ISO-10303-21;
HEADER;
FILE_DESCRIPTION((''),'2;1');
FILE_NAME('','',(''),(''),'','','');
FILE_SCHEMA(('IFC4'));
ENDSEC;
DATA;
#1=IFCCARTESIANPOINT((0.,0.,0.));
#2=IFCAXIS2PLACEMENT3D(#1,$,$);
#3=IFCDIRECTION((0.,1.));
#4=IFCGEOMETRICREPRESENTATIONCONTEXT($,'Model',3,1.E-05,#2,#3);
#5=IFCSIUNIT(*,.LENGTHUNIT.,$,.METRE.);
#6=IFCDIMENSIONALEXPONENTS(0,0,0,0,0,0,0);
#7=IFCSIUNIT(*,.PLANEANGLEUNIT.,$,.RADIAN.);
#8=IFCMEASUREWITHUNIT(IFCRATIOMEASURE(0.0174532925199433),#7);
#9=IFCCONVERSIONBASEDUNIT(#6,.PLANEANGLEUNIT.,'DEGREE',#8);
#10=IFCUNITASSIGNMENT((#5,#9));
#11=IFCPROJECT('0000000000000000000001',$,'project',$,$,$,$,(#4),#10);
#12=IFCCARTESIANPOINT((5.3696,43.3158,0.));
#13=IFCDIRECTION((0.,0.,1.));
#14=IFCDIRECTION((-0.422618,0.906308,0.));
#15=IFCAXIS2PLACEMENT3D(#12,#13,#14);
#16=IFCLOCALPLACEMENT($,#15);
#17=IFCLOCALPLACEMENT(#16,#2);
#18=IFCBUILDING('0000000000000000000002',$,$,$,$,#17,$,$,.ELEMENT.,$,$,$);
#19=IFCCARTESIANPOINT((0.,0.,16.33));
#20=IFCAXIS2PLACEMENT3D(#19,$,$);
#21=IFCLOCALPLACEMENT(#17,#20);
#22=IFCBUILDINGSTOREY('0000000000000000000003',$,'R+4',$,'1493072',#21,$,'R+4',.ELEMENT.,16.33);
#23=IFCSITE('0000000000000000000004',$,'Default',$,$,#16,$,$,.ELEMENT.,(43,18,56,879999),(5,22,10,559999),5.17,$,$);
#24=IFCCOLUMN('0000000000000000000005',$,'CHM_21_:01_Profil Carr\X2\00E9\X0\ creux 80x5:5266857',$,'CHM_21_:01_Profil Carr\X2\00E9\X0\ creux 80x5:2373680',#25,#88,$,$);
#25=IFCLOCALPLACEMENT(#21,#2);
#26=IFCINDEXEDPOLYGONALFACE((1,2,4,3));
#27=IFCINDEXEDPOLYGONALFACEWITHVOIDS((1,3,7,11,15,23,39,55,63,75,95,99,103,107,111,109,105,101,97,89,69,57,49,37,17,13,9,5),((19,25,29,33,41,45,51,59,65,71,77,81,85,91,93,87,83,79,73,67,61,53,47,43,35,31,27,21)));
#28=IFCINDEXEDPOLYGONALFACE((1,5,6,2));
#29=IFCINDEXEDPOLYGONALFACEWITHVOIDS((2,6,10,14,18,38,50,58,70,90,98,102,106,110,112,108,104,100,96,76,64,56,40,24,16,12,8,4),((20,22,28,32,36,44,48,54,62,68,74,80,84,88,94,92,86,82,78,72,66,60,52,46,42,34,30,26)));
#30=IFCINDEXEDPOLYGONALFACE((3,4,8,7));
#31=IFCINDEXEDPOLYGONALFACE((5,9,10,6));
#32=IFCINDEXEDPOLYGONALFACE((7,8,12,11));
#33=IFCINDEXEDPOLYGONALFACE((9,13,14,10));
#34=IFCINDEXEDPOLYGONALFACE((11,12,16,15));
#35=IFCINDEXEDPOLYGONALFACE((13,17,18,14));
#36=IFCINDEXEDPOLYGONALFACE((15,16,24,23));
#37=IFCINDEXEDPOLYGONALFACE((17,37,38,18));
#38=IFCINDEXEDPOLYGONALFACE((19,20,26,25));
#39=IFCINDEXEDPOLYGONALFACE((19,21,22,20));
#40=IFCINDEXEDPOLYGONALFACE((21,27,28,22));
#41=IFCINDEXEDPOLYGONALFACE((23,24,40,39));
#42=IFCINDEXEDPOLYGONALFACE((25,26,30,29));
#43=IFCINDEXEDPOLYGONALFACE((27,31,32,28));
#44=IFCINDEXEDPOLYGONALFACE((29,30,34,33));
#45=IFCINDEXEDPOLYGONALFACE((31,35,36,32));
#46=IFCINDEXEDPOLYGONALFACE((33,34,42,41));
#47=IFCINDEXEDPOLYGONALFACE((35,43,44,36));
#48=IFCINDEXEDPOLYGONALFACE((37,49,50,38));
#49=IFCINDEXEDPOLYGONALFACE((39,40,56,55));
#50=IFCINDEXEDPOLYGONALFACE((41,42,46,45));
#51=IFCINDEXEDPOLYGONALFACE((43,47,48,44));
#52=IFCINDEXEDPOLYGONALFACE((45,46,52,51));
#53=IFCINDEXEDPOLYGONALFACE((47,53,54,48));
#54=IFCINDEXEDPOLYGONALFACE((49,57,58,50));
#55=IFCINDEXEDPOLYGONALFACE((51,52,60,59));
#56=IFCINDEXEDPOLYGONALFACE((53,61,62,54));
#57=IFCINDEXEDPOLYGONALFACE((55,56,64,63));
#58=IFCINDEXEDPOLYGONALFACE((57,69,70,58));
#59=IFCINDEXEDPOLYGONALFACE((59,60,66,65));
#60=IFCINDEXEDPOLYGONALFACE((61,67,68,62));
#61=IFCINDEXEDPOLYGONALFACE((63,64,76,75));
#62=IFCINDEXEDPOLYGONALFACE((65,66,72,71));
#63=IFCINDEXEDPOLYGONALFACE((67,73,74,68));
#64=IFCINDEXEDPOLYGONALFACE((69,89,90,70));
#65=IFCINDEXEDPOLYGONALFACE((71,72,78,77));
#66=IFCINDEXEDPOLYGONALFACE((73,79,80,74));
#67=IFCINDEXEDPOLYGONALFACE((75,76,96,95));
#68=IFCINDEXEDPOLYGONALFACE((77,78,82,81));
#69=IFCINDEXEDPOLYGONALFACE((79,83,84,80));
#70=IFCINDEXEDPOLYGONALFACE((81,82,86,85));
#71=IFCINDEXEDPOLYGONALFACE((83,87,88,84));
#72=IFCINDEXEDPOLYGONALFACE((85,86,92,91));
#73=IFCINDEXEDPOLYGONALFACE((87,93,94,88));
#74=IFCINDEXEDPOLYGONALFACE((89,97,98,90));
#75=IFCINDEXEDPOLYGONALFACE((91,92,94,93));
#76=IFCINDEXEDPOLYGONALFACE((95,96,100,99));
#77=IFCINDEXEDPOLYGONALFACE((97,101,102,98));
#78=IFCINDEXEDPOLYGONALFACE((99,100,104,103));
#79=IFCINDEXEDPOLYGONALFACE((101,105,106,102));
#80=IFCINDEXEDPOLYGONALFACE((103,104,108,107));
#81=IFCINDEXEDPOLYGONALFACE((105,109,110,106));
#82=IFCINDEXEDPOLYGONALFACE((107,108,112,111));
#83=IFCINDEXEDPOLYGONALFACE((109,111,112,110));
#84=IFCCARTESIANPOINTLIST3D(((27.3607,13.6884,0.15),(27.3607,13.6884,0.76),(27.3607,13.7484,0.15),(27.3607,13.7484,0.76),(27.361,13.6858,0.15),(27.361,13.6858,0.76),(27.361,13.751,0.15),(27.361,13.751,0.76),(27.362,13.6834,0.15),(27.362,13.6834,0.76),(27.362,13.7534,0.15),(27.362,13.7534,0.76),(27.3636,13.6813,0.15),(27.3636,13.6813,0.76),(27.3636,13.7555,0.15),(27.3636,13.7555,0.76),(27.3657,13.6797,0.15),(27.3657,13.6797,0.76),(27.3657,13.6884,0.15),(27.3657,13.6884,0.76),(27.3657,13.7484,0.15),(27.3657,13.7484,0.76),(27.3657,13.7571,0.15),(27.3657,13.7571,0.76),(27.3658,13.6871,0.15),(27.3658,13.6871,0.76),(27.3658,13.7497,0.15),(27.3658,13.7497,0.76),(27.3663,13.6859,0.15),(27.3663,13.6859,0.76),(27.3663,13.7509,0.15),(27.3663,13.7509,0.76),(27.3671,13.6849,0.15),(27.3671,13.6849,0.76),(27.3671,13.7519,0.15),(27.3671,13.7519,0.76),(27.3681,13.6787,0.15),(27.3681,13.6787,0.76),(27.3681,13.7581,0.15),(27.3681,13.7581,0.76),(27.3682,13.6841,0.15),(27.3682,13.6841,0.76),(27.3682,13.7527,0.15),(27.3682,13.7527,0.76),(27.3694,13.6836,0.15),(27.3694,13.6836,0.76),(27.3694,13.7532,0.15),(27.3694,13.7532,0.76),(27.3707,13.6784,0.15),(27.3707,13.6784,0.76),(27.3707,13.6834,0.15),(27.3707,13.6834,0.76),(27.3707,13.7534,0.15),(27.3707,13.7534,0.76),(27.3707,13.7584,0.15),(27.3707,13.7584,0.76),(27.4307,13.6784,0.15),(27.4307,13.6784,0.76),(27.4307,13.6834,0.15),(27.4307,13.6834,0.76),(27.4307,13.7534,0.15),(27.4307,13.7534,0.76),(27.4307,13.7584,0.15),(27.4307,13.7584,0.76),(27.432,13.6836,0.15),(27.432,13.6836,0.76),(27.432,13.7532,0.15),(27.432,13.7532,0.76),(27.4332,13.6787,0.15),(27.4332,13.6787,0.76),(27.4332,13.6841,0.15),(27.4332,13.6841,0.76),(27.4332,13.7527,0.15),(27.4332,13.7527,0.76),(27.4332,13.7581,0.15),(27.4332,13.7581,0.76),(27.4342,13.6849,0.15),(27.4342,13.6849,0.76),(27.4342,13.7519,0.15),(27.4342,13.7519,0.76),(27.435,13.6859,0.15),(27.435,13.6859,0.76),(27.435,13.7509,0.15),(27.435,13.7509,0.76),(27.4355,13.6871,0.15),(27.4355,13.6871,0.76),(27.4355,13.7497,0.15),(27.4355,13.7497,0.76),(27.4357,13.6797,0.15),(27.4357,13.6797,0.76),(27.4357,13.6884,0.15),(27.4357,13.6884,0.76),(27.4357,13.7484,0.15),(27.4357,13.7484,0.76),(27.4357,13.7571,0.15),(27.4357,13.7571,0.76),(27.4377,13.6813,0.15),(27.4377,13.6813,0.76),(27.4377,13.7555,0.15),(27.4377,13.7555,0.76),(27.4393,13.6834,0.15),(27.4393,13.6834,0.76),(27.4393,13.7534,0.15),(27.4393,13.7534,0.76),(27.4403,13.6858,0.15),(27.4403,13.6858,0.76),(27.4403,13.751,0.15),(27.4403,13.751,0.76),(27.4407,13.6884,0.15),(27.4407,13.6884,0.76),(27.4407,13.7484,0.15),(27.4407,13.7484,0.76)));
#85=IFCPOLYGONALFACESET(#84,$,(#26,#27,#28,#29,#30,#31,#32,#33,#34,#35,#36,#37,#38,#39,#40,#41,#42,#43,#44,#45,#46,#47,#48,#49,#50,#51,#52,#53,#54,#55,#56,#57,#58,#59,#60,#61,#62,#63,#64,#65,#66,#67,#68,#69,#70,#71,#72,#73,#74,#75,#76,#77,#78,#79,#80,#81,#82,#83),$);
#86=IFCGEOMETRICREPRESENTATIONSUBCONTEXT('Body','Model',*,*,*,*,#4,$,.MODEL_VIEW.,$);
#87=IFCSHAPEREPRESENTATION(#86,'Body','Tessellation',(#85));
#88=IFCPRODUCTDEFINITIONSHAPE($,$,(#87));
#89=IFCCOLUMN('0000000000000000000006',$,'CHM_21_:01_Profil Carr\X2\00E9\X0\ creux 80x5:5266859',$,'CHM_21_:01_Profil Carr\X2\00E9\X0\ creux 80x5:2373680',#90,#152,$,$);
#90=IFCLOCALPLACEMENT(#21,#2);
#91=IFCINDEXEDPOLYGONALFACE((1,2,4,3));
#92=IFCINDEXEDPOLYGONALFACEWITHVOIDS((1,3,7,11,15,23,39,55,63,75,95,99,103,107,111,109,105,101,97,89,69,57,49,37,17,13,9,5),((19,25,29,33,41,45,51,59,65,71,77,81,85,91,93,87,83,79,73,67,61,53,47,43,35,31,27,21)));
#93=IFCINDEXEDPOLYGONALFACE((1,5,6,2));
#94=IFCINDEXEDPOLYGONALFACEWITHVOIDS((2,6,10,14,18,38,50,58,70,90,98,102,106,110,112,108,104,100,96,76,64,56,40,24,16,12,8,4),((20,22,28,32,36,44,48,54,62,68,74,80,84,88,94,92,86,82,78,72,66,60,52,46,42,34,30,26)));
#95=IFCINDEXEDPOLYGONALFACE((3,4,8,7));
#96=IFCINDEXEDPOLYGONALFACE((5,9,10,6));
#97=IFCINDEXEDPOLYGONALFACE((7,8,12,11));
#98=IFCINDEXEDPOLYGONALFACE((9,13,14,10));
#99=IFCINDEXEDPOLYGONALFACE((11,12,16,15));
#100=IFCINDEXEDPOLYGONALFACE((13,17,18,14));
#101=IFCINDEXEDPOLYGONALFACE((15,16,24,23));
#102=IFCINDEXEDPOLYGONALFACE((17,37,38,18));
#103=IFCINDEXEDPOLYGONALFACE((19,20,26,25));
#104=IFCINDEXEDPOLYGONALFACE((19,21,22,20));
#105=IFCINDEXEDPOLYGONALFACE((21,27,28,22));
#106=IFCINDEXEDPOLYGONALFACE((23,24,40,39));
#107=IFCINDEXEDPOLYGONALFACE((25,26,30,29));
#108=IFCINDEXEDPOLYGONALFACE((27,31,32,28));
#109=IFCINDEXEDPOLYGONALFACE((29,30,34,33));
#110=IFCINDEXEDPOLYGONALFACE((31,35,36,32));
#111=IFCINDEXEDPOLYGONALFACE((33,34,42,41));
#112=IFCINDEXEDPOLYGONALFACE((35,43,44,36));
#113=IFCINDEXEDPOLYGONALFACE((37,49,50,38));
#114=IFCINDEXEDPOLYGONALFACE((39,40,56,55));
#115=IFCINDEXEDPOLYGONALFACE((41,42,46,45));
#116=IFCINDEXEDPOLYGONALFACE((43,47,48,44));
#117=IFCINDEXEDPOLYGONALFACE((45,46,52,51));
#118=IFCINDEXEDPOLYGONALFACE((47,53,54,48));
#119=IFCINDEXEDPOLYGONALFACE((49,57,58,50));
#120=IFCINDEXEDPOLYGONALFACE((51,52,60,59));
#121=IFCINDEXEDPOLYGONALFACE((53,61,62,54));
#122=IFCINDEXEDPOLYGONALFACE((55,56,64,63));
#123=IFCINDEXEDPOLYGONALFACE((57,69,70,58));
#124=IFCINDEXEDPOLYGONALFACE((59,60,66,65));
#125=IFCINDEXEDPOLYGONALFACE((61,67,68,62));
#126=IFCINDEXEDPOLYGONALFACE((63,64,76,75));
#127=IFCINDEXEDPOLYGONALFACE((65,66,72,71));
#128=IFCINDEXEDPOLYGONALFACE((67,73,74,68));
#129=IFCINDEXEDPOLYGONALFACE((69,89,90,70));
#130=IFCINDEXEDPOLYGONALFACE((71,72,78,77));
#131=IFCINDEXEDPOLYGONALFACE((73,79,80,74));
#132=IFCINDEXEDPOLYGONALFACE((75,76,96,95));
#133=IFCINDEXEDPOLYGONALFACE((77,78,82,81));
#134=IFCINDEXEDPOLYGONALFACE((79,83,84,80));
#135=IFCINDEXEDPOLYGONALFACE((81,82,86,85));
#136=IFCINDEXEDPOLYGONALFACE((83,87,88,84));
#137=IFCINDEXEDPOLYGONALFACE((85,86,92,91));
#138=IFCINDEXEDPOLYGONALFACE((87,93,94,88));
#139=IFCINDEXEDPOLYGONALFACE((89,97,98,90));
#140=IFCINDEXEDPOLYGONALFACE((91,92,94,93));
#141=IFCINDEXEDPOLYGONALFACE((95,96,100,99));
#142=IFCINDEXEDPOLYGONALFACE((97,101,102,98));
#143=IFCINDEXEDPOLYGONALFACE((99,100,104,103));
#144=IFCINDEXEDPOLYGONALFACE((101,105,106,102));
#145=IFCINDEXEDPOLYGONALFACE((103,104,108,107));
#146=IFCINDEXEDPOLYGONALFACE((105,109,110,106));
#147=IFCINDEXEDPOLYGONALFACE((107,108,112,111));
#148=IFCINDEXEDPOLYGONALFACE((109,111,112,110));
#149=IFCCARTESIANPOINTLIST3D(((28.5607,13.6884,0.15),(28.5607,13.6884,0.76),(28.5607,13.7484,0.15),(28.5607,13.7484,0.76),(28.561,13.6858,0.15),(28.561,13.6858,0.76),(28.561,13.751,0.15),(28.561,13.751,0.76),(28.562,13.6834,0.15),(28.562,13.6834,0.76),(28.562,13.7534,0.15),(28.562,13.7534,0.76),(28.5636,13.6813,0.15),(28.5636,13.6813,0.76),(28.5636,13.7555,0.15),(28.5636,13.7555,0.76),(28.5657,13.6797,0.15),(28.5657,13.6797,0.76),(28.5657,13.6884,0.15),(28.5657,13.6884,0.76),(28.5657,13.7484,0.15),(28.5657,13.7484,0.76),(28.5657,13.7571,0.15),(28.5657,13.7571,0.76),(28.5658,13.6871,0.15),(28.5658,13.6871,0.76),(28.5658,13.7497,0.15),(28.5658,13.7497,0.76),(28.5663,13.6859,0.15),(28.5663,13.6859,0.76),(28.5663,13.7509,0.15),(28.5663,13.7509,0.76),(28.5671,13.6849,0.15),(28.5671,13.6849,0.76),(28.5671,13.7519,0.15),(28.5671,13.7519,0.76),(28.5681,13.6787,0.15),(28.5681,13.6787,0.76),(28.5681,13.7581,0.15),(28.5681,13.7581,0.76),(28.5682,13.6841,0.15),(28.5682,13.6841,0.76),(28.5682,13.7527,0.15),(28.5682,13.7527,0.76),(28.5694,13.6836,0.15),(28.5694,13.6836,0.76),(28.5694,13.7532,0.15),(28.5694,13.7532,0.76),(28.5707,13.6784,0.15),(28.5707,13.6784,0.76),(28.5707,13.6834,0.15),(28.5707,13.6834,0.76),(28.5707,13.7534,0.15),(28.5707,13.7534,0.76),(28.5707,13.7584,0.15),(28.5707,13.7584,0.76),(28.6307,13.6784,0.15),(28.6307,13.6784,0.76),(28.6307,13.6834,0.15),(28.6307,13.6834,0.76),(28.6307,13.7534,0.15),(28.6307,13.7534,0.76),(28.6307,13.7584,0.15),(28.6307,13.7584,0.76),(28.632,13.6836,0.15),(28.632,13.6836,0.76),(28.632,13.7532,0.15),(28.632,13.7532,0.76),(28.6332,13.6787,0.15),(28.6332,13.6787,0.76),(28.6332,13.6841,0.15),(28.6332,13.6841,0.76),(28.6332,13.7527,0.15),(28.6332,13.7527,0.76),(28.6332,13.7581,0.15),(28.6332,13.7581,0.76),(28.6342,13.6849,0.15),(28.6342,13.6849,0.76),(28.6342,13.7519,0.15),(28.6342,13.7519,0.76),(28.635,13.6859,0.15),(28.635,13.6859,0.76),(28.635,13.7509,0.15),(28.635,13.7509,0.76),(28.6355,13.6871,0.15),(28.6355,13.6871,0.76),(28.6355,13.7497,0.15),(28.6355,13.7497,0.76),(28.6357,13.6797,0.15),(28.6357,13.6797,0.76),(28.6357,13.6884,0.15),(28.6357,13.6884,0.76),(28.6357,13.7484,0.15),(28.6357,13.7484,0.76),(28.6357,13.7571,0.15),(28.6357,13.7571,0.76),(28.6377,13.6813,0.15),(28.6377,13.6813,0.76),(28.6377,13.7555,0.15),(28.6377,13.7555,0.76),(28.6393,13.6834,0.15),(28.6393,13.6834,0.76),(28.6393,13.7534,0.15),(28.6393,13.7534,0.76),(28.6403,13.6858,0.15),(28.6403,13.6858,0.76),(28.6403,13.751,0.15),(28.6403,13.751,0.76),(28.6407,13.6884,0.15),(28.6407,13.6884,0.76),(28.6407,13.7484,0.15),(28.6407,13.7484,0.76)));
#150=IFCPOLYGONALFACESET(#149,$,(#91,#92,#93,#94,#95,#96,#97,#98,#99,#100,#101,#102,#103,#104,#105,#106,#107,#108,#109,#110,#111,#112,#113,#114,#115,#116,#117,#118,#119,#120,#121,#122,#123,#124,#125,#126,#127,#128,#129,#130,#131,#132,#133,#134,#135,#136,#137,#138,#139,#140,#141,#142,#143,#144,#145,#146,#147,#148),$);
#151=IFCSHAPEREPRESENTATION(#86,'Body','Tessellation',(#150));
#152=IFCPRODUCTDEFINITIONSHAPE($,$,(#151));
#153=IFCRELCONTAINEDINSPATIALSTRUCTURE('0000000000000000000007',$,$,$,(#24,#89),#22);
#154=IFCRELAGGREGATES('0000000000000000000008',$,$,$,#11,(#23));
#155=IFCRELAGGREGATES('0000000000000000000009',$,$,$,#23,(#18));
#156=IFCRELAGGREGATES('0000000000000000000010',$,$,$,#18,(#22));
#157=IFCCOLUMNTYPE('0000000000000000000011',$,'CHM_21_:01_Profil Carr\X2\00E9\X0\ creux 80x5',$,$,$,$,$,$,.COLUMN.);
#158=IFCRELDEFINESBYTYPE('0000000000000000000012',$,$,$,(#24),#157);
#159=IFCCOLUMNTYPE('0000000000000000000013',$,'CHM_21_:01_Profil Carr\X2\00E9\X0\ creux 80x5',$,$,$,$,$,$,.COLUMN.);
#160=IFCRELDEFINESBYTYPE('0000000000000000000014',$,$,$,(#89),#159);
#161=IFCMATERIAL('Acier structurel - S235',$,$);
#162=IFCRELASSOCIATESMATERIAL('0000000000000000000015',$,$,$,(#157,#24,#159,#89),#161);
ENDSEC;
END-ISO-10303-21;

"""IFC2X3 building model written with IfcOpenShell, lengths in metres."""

from ifc_helpers import new_model, entity, si_unit, converted_unit, direction, frame, frame_2d, origin, place, context, subcontext, project, spatial, polyline, circle_curve, parameter, trimmed, segment, composite_curve, outline, extrude, source, transform, mapped, material, type_object, type_shapes, element, save


model = new_model("IFC2X3")

# Units and contexts
model_context = context("Model", 3, precision=1e-05, world=origin(), true_north=direction((0.0, 1.0)))
body_context = subcontext(model_context, "Body", "Model", "MODEL_VIEW")
ifc_project = project(units=[si_unit("LENGTHUNIT", "METRE"), converted_unit("PLANEANGLEUNIT", "DEGREE", entity("IfcRatioMeasure", 0.0174532925199433), si_unit("PLANEANGLEUNIT", "RADIAN"), dimensions=[0, 0, 0, 0, 0, 0, 0])], contexts=[model_context])

# Site, building, storey
site_placement = place(None, frame((5.3696, 43.3158, 0.0), z_axis=(0.0, 0.0, 1.0), x_axis=(-0.422618, 0.906308, 0.0)))
site = spatial("IfcSite", under=ifc_project, at=site_placement, Name="Default", CompositionType="ELEMENT", RefLatitude=(43, 18, 56, 879999), RefLongitude=(5, 22, 10, 559999), RefElevation=5.17)
building_placement = place(site_placement, origin())
building = spatial("IfcBuilding", under=site, at=building_placement, CompositionType="ELEMENT")
storey_placement = place(building_placement, frame((0.0, 0.0, 16.33)))
storey = spatial("IfcBuildingStorey", under=building, at=storey_placement, Name="R+4", ObjectType="1493072", LongName="R+4", CompositionType="ELEMENT", Elevation=16.33)

# Columns
ifc_material_1 = material(Name="Acier structurel - S235")
column_type_1 = type_object("IfcColumnType", Name="CHM_21_:01_Profil Carré creux 80x5", PredefinedType="COLUMN", material=ifc_material_1)
shared_shape_1 = source(origin(), body_context, "Body", "SweptSolid", [
    extrude(outline(composite_curve([segment(polyline([(-0.03, -0.04), (0.03, -0.04)]), True, "CONTINUOUS"), segment(trimmed(circle_curve(frame_2d((0.03, -0.03), x_axis=(-1.0, 0.0)), 0.01), [parameter(90.0)], [parameter(180.0)], True, "PARAMETER"), True, "CONTINUOUS"), segment(polyline([(0.04, -0.03), (0.04, 0.03)]), True, "CONTINUOUS"), segment(trimmed(circle_curve(frame_2d((0.03, 0.03), x_axis=(-1.0, 0.0)), 0.01), [parameter(180.0)], [parameter(270.0)], True, "PARAMETER"), True, "CONTINUOUS"), segment(polyline([(0.03, 0.04), (-0.03, 0.04)]), True, "CONTINUOUS"), segment(trimmed(circle_curve(frame_2d((-0.03, 0.03), x_axis=(-1.0, 0.0)), 0.01), [parameter(270.0)], [parameter(360.0)], True, "PARAMETER"), True, "CONTINUOUS"), segment(polyline([(-0.04, 0.03), (-0.04, -0.03)]), True, "CONTINUOUS"), segment(trimmed(circle_curve(frame_2d((-0.03, -0.03), x_axis=(-1.0, 0.0)), 0.01), [parameter(360.0)], [parameter(90.0)], True, "PARAMETER"), True, "CONTINUOUS")], self_intersect=False), holes=[composite_curve([segment(trimmed(circle_curve(frame_2d((-0.03, -0.03), x_axis=(-1.0, 0.0)), 0.005), [parameter(360.0)], [parameter(90.0)], True, "PARAMETER"), False, "CONTINUOUS"), segment(polyline([(-0.035, -0.03), (-0.035, 0.03)]), True, "CONTINUOUS"), segment(trimmed(circle_curve(frame_2d((-0.03, 0.03), x_axis=(-1.0, 0.0)), 0.005), [parameter(270.0)], [parameter(360.0)], True, "PARAMETER"), False, "CONTINUOUS"), segment(polyline([(-0.03, 0.035), (0.03, 0.035)]), True, "CONTINUOUS"), segment(trimmed(circle_curve(frame_2d((0.03, 0.03), x_axis=(-1.0, 0.0)), 0.005), [parameter(180.0)], [parameter(270.0)], True, "PARAMETER"), False, "CONTINUOUS"), segment(polyline([(0.035, 0.03), (0.035, -0.03)]), True, "CONTINUOUS"), segment(trimmed(circle_curve(frame_2d((0.03, -0.03), x_axis=(-1.0, 0.0)), 0.005), [parameter(90.0)], [parameter(180.0)], True, "PARAMETER"), False, "CONTINUOUS"), segment(polyline([(0.03, -0.035), (-0.03, -0.035)]), True, "CONTINUOUS")], self_intersect=False)]), frame((27.4007, 13.7184, 16.48), z_axis=(0.0, 0.0, 1.0), x_axis=(0.0, 1.0, 0.0)), (0.0, 0.0, 1.0), 0.61),
])
type_shapes(column_type_1, [shared_shape_1])
column_1_placement = place(storey_placement, frame((0.0, 0.0, -16.33)))
element("IfcColumn", 1, at=column_1_placement, inside=storey, type_object=column_type_1, material=ifc_material_1, Name="CHM_21_:01_Profil Carré creux 80x5:5266857", ObjectType="CHM_21_:01_Profil Carré creux 80x5:2373680", context=body_context, shape_type="MappedRepresentation", body=[
    mapped(shared_shape_1, transform((0.0, 0.0, 0.0), scale=1.0)),
])
column_type_2 = type_object("IfcColumnType", Name="CHM_21_:01_Profil Carré creux 80x5", PredefinedType="COLUMN", material=ifc_material_1)
shared_shape_2 = source(origin(), body_context, "Body", "SweptSolid", [
    extrude(outline(composite_curve([segment(polyline([(-0.03, -0.04), (0.03, -0.04)]), True, "CONTINUOUS"), segment(trimmed(circle_curve(frame_2d((0.03, -0.03), x_axis=(-1.0, 0.0)), 0.01), [parameter(90.0)], [parameter(180.0)], True, "PARAMETER"), True, "CONTINUOUS"), segment(polyline([(0.04, -0.03), (0.04, 0.03)]), True, "CONTINUOUS"), segment(trimmed(circle_curve(frame_2d((0.03, 0.03), x_axis=(-1.0, 0.0)), 0.01), [parameter(180.0)], [parameter(270.0)], True, "PARAMETER"), True, "CONTINUOUS"), segment(polyline([(0.03, 0.04), (-0.03, 0.04)]), True, "CONTINUOUS"), segment(trimmed(circle_curve(frame_2d((-0.03, 0.03), x_axis=(-1.0, 0.0)), 0.01), [parameter(270.0)], [parameter(360.0)], True, "PARAMETER"), True, "CONTINUOUS"), segment(polyline([(-0.04, 0.03), (-0.04, -0.03)]), True, "CONTINUOUS"), segment(trimmed(circle_curve(frame_2d((-0.03, -0.03), x_axis=(-1.0, 0.0)), 0.01), [parameter(360.0)], [parameter(90.0)], True, "PARAMETER"), True, "CONTINUOUS")], self_intersect=False), holes=[composite_curve([segment(trimmed(circle_curve(frame_2d((-0.03, -0.03), x_axis=(-1.0, 0.0)), 0.005), [parameter(360.0)], [parameter(90.0)], True, "PARAMETER"), False, "CONTINUOUS"), segment(polyline([(-0.035, -0.03), (-0.035, 0.03)]), True, "CONTINUOUS"), segment(trimmed(circle_curve(frame_2d((-0.03, 0.03), x_axis=(-1.0, 0.0)), 0.005), [parameter(270.0)], [parameter(360.0)], True, "PARAMETER"), False, "CONTINUOUS"), segment(polyline([(-0.03, 0.035), (0.03, 0.035)]), True, "CONTINUOUS"), segment(trimmed(circle_curve(frame_2d((0.03, 0.03), x_axis=(-1.0, 0.0)), 0.005), [parameter(180.0)], [parameter(270.0)], True, "PARAMETER"), False, "CONTINUOUS"), segment(polyline([(0.035, 0.03), (0.035, -0.03)]), True, "CONTINUOUS"), segment(trimmed(circle_curve(frame_2d((0.03, -0.03), x_axis=(-1.0, 0.0)), 0.005), [parameter(90.0)], [parameter(180.0)], True, "PARAMETER"), False, "CONTINUOUS"), segment(polyline([(0.03, -0.035), (-0.03, -0.035)]), True, "CONTINUOUS")], self_intersect=False)]), frame((28.6007, 13.7184, 16.48), z_axis=(0.0, 0.0, 1.0), x_axis=(0.0, 1.0, 0.0)), (0.0, 0.0, 1.0), 0.61),
])
type_shapes(column_type_2, [shared_shape_2])
column_2_placement = place(storey_placement, frame((0.0, 0.0, -16.33)))
element("IfcColumn", 2, at=column_2_placement, inside=storey, type_object=column_type_2, material=ifc_material_1, Name="CHM_21_:01_Profil Carré creux 80x5:5266859", ObjectType="CHM_21_:01_Profil Carré creux 80x5:2373680", context=body_context, shape_type="MappedRepresentation", body=[
    mapped(shared_shape_2, transform((0.0, 0.0, 0.0), scale=1.0)),
])

save(model, "model.ifc")
